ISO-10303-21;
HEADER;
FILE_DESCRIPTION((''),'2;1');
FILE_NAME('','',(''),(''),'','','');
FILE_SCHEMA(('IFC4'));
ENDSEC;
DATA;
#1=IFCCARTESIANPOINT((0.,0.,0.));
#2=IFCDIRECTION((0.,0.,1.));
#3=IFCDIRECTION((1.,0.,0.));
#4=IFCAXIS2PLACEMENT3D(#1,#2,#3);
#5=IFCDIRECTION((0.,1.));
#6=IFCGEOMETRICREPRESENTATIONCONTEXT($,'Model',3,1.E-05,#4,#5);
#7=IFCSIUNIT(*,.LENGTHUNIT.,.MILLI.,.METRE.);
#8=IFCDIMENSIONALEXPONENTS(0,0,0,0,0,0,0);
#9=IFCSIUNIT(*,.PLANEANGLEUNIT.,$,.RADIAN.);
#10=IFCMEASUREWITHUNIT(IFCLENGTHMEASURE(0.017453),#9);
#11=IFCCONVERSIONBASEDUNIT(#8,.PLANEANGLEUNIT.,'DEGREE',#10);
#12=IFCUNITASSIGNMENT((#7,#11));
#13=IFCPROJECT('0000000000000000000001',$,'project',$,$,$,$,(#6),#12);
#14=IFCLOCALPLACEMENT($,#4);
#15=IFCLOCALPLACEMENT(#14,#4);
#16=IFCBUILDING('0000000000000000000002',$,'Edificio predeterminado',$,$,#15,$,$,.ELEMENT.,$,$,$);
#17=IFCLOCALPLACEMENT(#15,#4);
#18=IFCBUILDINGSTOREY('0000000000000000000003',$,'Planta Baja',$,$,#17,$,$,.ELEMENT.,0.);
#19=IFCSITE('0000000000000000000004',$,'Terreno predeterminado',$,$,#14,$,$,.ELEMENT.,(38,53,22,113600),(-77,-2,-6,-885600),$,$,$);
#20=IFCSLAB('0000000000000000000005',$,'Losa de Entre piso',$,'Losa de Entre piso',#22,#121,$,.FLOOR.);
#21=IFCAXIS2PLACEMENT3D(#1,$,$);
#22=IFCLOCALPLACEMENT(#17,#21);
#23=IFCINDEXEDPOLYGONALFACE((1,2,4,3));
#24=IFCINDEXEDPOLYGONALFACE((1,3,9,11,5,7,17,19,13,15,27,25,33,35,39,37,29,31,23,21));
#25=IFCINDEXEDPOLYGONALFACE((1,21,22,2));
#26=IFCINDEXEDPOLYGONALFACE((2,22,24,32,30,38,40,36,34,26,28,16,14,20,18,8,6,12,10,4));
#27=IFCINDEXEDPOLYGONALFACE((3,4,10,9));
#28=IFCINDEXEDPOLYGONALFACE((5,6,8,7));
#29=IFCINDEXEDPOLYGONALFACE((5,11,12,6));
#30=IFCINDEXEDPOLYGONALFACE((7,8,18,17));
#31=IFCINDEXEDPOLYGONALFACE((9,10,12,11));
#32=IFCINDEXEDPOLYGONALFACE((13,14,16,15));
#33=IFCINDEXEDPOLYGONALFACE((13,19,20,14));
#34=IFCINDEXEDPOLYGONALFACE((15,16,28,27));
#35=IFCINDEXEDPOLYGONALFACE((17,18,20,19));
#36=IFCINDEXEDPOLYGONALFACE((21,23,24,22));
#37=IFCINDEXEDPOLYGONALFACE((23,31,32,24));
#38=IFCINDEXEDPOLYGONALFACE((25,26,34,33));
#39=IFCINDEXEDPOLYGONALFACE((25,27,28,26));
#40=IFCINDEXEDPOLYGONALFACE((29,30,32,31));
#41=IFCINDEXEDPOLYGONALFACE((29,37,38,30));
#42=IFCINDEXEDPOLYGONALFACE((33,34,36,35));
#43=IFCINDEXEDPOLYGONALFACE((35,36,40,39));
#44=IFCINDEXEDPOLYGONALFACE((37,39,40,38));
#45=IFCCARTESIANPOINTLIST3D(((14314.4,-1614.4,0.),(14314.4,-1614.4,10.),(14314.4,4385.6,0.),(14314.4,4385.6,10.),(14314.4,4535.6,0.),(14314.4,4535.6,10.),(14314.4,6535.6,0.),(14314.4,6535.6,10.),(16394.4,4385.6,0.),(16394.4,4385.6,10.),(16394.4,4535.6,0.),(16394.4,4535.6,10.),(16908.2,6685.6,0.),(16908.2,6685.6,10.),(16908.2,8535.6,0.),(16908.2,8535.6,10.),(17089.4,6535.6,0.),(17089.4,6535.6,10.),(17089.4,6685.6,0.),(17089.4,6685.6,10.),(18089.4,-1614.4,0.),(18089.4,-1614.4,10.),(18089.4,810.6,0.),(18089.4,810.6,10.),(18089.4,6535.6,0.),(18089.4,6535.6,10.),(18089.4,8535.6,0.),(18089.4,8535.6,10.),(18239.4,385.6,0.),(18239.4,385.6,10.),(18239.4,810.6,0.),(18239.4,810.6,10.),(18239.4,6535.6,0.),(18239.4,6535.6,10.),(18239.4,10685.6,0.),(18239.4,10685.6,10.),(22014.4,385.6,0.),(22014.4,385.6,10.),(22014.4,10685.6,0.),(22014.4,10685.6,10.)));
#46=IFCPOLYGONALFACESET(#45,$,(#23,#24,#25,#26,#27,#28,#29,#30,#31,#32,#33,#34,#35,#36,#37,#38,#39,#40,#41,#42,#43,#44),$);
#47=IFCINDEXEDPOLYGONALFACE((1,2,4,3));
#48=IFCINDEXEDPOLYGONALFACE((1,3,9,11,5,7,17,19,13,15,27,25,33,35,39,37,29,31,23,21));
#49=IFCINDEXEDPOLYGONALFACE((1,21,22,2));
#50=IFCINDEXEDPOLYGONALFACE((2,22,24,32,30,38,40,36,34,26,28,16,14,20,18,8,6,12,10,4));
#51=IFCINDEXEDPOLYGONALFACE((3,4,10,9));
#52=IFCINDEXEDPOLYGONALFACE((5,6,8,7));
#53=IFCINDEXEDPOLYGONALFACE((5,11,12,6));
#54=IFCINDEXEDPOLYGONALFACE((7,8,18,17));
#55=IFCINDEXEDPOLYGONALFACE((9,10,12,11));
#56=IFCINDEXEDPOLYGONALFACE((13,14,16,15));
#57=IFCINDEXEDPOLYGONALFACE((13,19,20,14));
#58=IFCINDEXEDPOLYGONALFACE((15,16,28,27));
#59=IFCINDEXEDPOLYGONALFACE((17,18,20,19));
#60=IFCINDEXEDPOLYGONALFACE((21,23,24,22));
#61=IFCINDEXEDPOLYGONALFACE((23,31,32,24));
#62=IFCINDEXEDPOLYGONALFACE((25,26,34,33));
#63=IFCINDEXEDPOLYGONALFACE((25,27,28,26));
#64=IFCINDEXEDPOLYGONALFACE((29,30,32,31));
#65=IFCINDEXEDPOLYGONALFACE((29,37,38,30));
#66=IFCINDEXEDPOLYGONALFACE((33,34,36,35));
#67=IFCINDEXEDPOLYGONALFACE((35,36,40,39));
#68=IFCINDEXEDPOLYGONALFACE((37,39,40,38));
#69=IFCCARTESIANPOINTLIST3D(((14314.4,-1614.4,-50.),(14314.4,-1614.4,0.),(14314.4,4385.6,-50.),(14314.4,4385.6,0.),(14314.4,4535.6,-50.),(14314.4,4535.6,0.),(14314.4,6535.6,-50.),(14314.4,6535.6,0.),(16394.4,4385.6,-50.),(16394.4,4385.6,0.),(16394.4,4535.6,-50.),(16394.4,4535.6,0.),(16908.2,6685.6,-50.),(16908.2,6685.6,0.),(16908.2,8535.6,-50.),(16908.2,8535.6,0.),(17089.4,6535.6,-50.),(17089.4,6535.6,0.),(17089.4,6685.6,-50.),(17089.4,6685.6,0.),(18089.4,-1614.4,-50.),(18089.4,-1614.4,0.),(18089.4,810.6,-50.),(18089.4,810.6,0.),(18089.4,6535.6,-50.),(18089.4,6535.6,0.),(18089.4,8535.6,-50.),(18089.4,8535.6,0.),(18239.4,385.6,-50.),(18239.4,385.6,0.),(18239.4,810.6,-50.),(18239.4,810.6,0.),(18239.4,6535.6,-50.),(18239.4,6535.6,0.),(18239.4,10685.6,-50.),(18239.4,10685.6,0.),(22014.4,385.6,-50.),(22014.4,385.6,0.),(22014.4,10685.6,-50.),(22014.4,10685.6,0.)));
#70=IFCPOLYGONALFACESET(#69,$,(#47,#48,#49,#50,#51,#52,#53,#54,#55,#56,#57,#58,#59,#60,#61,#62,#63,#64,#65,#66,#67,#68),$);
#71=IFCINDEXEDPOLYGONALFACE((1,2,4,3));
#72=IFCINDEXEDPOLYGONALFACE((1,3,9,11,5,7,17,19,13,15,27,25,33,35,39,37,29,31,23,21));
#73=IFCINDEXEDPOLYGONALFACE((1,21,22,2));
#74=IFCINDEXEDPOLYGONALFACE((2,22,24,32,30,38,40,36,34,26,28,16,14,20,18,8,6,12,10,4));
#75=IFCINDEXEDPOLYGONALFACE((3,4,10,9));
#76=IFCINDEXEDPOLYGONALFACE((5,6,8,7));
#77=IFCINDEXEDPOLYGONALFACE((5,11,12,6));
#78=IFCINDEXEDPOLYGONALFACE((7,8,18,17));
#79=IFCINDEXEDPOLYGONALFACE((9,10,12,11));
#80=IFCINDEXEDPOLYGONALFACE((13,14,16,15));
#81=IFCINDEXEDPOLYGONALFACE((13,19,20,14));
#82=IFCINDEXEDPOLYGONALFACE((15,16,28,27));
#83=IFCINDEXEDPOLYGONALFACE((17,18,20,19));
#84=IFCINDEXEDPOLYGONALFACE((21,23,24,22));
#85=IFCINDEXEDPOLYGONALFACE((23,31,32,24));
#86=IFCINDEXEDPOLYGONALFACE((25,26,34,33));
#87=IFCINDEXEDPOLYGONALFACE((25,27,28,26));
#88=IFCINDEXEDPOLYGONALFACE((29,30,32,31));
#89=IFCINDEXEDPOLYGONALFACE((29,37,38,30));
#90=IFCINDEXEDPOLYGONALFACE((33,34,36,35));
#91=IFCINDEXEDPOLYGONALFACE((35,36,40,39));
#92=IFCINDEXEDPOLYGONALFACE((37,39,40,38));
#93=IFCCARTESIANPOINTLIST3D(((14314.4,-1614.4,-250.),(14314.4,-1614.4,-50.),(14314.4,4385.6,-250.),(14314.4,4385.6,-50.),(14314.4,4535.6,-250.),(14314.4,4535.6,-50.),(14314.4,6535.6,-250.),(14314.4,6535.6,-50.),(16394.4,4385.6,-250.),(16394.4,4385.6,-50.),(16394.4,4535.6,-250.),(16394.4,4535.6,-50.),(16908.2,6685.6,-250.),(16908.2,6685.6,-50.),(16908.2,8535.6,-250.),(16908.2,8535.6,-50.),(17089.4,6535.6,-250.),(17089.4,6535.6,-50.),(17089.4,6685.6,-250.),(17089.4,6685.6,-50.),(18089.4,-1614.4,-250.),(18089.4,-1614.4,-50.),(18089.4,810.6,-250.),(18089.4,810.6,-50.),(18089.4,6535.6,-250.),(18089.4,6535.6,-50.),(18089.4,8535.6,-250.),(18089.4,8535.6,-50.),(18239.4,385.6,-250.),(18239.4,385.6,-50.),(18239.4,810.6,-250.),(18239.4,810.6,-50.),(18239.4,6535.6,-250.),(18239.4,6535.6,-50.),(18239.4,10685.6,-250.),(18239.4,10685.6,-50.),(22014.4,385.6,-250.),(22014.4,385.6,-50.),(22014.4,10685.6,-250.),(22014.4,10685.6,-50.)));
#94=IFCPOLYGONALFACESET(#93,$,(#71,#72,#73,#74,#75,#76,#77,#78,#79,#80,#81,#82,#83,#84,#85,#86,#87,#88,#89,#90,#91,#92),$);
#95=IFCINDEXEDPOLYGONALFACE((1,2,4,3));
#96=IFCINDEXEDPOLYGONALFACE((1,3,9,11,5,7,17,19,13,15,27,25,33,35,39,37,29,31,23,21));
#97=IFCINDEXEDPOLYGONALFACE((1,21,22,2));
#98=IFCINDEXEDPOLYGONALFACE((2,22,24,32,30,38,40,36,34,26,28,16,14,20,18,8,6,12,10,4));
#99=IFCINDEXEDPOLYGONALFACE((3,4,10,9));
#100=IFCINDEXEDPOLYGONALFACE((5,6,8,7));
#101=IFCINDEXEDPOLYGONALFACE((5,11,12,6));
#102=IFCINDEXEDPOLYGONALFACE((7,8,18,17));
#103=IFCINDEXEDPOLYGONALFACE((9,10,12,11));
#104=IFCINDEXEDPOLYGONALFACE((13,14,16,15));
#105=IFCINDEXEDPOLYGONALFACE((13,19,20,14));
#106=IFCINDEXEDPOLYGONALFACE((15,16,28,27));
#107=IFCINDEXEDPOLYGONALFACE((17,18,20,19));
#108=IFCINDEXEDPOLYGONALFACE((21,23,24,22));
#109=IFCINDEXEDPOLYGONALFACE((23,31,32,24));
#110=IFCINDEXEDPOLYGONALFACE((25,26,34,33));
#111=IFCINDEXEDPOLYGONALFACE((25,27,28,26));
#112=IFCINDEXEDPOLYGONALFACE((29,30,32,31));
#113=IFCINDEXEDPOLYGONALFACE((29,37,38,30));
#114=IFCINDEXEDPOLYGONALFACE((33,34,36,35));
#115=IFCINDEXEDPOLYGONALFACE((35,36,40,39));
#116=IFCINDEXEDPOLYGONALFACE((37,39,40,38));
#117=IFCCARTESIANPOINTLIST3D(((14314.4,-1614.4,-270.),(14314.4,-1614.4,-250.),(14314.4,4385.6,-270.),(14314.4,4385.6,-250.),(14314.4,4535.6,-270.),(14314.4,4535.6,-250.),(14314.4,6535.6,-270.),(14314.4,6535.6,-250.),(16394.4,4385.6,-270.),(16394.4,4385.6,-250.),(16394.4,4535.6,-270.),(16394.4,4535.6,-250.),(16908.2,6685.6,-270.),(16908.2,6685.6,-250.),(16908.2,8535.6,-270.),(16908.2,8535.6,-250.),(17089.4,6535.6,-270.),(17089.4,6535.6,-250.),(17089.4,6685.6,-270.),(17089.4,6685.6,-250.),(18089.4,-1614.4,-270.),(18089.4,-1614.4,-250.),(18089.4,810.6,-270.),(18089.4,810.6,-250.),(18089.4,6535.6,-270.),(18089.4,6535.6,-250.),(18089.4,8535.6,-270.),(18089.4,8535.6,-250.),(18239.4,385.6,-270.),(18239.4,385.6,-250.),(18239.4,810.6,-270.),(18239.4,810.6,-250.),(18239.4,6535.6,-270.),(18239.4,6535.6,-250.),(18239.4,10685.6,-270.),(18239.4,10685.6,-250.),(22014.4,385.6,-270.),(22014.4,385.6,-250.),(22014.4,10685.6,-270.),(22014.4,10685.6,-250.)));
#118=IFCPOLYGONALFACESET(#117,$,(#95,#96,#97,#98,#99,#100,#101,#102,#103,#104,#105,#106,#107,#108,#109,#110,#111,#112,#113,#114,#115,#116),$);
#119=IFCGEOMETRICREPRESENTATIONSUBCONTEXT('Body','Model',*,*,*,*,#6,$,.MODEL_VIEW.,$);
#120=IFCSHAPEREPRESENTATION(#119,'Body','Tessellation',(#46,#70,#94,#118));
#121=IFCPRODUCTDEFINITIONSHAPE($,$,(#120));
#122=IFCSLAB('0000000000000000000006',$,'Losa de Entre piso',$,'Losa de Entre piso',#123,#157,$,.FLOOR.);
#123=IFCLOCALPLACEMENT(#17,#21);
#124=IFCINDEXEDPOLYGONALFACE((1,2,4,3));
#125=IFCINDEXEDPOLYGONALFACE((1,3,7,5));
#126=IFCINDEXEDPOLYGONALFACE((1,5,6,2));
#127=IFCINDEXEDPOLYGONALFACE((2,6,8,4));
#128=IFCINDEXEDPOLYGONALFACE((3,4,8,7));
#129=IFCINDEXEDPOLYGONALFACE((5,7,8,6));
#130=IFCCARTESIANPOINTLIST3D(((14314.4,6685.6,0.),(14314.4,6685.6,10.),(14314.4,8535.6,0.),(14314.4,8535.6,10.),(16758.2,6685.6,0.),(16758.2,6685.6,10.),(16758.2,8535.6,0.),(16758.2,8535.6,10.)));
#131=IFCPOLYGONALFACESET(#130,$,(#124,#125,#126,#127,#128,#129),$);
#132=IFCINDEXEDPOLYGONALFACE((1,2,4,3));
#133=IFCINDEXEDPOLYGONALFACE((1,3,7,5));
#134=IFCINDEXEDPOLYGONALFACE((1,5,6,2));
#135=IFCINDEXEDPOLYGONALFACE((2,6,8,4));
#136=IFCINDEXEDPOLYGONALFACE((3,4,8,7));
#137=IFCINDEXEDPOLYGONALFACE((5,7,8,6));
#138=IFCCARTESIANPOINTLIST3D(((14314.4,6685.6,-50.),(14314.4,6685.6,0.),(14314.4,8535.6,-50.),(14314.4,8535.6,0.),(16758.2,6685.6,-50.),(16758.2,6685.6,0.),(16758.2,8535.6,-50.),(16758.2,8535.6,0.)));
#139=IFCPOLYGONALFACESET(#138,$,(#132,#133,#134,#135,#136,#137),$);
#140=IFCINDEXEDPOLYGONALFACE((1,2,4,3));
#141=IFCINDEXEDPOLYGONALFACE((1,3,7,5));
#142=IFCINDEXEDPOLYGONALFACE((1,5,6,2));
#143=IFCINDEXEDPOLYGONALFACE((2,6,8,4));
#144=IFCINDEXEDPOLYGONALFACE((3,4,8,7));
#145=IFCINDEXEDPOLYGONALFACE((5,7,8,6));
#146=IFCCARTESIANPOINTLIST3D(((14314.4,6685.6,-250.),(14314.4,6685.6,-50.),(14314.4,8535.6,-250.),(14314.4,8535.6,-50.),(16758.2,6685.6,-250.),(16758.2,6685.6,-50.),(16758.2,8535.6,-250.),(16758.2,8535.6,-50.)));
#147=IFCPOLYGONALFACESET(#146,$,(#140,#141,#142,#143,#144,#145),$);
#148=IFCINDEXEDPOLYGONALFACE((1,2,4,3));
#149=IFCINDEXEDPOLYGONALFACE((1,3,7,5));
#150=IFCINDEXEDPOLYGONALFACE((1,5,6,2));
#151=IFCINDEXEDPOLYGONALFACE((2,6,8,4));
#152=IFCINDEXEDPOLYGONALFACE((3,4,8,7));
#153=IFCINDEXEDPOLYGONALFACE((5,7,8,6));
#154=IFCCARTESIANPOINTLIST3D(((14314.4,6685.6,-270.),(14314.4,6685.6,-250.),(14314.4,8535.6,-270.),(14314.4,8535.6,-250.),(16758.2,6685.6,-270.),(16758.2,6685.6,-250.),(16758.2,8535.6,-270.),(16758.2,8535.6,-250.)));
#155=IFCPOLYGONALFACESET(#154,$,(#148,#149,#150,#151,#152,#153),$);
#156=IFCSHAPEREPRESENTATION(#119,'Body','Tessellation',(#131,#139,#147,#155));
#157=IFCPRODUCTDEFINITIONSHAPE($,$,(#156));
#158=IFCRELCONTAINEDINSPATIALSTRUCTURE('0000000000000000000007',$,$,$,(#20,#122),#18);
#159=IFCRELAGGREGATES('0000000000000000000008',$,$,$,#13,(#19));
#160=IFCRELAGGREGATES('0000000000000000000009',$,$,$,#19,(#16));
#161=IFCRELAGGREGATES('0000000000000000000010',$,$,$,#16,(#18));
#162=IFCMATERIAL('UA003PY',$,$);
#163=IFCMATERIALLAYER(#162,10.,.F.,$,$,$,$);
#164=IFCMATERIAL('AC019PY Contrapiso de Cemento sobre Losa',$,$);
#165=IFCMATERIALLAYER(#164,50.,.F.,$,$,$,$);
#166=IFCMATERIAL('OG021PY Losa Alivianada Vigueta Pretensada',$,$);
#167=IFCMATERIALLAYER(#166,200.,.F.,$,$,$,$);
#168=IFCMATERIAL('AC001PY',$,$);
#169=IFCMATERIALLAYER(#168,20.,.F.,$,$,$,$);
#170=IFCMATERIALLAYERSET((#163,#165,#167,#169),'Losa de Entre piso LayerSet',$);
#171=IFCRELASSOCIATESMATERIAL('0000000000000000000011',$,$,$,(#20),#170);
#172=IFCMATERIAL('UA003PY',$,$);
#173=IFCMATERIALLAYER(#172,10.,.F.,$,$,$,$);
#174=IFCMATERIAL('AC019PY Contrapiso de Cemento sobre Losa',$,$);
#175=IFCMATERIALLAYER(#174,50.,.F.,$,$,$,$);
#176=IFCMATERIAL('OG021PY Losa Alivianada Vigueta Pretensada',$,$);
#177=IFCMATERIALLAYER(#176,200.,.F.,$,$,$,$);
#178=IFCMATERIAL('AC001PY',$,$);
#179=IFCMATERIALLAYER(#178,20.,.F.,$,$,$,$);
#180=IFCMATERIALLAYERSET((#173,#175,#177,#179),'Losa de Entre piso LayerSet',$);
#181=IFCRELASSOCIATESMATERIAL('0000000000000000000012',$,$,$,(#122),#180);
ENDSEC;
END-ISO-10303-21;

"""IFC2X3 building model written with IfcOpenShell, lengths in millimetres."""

from ifc_helpers import new_model, entity, si_unit, converted_unit, direction, frame, origin_with_axes, place, context, subcontext, project, spatial, polyline, outline, extrude, material, layer, layer_set, layer_usage, element, save


model = new_model("IFC2X3")

# Units and contexts
model_context = context("Model", 3, precision=1e-05, world=origin_with_axes(), true_north=direction((0.0, 1.0)))
body_context = subcontext(model_context, "Body", "Model", "MODEL_VIEW")
ifc_project = project(units=[si_unit("LENGTHUNIT", "METRE", prefix="MILLI"), converted_unit("PLANEANGLEUNIT", "DEGREE", entity("IfcLengthMeasure", 0.017453), si_unit("PLANEANGLEUNIT", "RADIAN"), dimensions=[0, 0, 0, 0, 0, 0, 0])], contexts=[model_context])

# Site, building, storey
site_placement = place(None, origin_with_axes())
site = spatial("IfcSite", under=ifc_project, at=site_placement, Name="Terreno predeterminado", CompositionType="ELEMENT", RefLatitude=(38, 53, 22, 113600), RefLongitude=(-77, -2, -6, -885600))
building_placement = place(site_placement, origin_with_axes())
building = spatial("IfcBuilding", under=site, at=building_placement, Name="Edificio predeterminado", CompositionType="ELEMENT")
storey_placement = place(building_placement, origin_with_axes())
storey = spatial("IfcBuildingStorey", under=building, at=storey_placement, Name="Planta Baja", CompositionType="ELEMENT", Elevation=0.0)

# Slabs
ifc_material_1 = material(Name="UA003PY")
ifc_layer_1 = layer(ifc_material_1, 10.0, ventilated=False)
ifc_material_2 = material(Name="AC019PY Contrapiso de Cemento sobre Losa")
ifc_layer_2 = layer(ifc_material_2, 50.0, ventilated=False)
ifc_material_3 = material(Name="OG021PY Losa Alivianada Vigueta Pretensada")
ifc_layer_3 = layer(ifc_material_3, 200.0, ventilated=False)
ifc_material_4 = material(Name="AC001PY")
ifc_layer_4 = layer(ifc_material_4, 20.0, ventilated=False)
ifc_layer_set_1 = layer_set([ifc_layer_1, ifc_layer_2, ifc_layer_3, ifc_layer_4], Name="Losa de Entre piso LayerSet")
ifc_layer_usage_1 = layer_usage(ifc_layer_set_1, "AXIS3", "POSITIVE", 0.0)
slab_1_placement = place(storey_placement, origin_with_axes())
element("IfcSlab", 1, at=slab_1_placement, inside=storey, material=ifc_layer_usage_1, Name="Losa de Entre piso", ObjectType="Losa de Entre piso", PredefinedType="FLOOR", context=body_context, shape_type="SweptSolid", body=[
    extrude(outline(polyline([(0.0, -6000.0), (3775.0, -6000.0), (3775.0, -3575.0), (3925.0, -3575.0), (3925.0, -4000.0), (7700.0, -4000.0), (7700.0, 6300.0), (3925.0, 6300.0), (3925.0, 2150.0), (3775.0, 2150.0), (3775.0, 4150.0), (2593.9, 4150.0), (2593.9, 2300.0), (2775.0, 2300.0), (2775.0, 2150.0), (0.0, 2150.0), (0.0, 150.0), (2080.0, 150.0), (2080.0, 0.0), (0.0, 0.0), (0.0, -6000.0)])), frame((14314.4, 4385.6, 0.0), z_axis=(0.0, 0.0, 1.0), x_axis=(1.0, 0.0, 0.0)), (0.0, 0.0, 1.0), 10.0),
    extrude(outline(polyline([(0.0, -6000.0), (3775.0, -6000.0), (3775.0, -3575.0), (3925.0, -3575.0), (3925.0, -4000.0), (7700.0, -4000.0), (7700.0, 6300.0), (3925.0, 6300.0), (3925.0, 2150.0), (3775.0, 2150.0), (3775.0, 4150.0), (2593.9, 4150.0), (2593.9, 2300.0), (2775.0, 2300.0), (2775.0, 2150.0), (0.0, 2150.0), (0.0, 150.0), (2080.0, 150.0), (2080.0, 0.0), (0.0, 0.0), (0.0, -6000.0)])), frame((14314.4, 4385.6, -50.0), z_axis=(0.0, 0.0, 1.0), x_axis=(1.0, 0.0, 0.0)), (0.0, 0.0, 1.0), 50.0),
    extrude(outline(polyline([(0.0, -6000.0), (3775.0, -6000.0), (3775.0, -3575.0), (3925.0, -3575.0), (3925.0, -4000.0), (7700.0, -4000.0), (7700.0, 6300.0), (3925.0, 6300.0), (3925.0, 2150.0), (3775.0, 2150.0), (3775.0, 4150.0), (2593.9, 4150.0), (2593.9, 2300.0), (2775.0, 2300.0), (2775.0, 2150.0), (0.0, 2150.0), (0.0, 150.0), (2080.0, 150.0), (2080.0, 0.0), (0.0, 0.0), (0.0, -6000.0)])), frame((14314.4, 4385.6, -250.0), z_axis=(0.0, 0.0, 1.0), x_axis=(1.0, 0.0, 0.0)), (0.0, 0.0, 1.0), 200.0),
    extrude(outline(polyline([(0.0, -6000.0), (3775.0, -6000.0), (3775.0, -3575.0), (3925.0, -3575.0), (3925.0, -4000.0), (7700.0, -4000.0), (7700.0, 6300.0), (3925.0, 6300.0), (3925.0, 2150.0), (3775.0, 2150.0), (3775.0, 4150.0), (2593.9, 4150.0), (2593.9, 2300.0), (2775.0, 2300.0), (2775.0, 2150.0), (0.0, 2150.0), (0.0, 150.0), (2080.0, 150.0), (2080.0, 0.0), (0.0, 0.0), (0.0, -6000.0)])), frame((14314.4, 4385.6, -270.0), z_axis=(0.0, 0.0, 1.0), x_axis=(1.0, 0.0, 0.0)), (0.0, 0.0, 1.0), 20.0),
])
ifc_material_5 = material(Name="UA003PY")
ifc_layer_5 = layer(ifc_material_5, 10.0, ventilated=False)
ifc_material_6 = material(Name="AC019PY Contrapiso de Cemento sobre Losa")
ifc_layer_6 = layer(ifc_material_6, 50.0, ventilated=False)
ifc_material_7 = material(Name="OG021PY Losa Alivianada Vigueta Pretensada")
ifc_layer_7 = layer(ifc_material_7, 200.0, ventilated=False)
ifc_material_8 = material(Name="AC001PY")
ifc_layer_8 = layer(ifc_material_8, 20.0, ventilated=False)
ifc_layer_set_2 = layer_set([ifc_layer_5, ifc_layer_6, ifc_layer_7, ifc_layer_8], Name="Losa de Entre piso LayerSet")
ifc_layer_usage_2 = layer_usage(ifc_layer_set_2, "AXIS3", "NEGATIVE", 0.0)
slab_2_placement = place(storey_placement, origin_with_axes())
element("IfcSlab", 2, at=slab_2_placement, inside=storey, material=ifc_layer_usage_2, Name="Losa de Entre piso", ObjectType="Losa de Entre piso", PredefinedType="FLOOR", context=body_context, shape_type="SweptSolid", body=[
    extrude(outline(polyline([(0.0, 2443.9), (1850.0, 2443.9), (1850.0, 0.0), (0.0, 0.0), (0.0, 2443.9)])), frame((14314.4, 6685.6, 0.0), z_axis=(0.0, 0.0, -1.0), x_axis=(0.0, 1.0, 0.0)), (0.0, 0.0, -1.0), 10.0),
    extrude(outline(polyline([(0.0, 2443.9), (1850.0, 2443.9), (1850.0, 0.0), (0.0, 0.0), (0.0, 2443.9)])), frame((14314.4, 6685.6, -50.0), z_axis=(0.0, 0.0, -1.0), x_axis=(0.0, 1.0, 0.0)), (0.0, 0.0, -1.0), 50.0),
    extrude(outline(polyline([(0.0, 2443.9), (1850.0, 2443.9), (1850.0, 0.0), (0.0, 0.0), (0.0, 2443.9)])), frame((14314.4, 6685.6, -250.0), z_axis=(0.0, 0.0, -1.0), x_axis=(0.0, 1.0, 0.0)), (0.0, 0.0, -1.0), 200.0),
    extrude(outline(polyline([(0.0, 2443.9), (1850.0, 2443.9), (1850.0, 0.0), (0.0, 0.0), (0.0, 2443.9)])), frame((14314.4, 6685.6, -270.0), z_axis=(0.0, 0.0, -1.0), x_axis=(0.0, 1.0, 0.0)), (0.0, 0.0, -1.0), 20.0),
])

save(model, "model.ifc")
